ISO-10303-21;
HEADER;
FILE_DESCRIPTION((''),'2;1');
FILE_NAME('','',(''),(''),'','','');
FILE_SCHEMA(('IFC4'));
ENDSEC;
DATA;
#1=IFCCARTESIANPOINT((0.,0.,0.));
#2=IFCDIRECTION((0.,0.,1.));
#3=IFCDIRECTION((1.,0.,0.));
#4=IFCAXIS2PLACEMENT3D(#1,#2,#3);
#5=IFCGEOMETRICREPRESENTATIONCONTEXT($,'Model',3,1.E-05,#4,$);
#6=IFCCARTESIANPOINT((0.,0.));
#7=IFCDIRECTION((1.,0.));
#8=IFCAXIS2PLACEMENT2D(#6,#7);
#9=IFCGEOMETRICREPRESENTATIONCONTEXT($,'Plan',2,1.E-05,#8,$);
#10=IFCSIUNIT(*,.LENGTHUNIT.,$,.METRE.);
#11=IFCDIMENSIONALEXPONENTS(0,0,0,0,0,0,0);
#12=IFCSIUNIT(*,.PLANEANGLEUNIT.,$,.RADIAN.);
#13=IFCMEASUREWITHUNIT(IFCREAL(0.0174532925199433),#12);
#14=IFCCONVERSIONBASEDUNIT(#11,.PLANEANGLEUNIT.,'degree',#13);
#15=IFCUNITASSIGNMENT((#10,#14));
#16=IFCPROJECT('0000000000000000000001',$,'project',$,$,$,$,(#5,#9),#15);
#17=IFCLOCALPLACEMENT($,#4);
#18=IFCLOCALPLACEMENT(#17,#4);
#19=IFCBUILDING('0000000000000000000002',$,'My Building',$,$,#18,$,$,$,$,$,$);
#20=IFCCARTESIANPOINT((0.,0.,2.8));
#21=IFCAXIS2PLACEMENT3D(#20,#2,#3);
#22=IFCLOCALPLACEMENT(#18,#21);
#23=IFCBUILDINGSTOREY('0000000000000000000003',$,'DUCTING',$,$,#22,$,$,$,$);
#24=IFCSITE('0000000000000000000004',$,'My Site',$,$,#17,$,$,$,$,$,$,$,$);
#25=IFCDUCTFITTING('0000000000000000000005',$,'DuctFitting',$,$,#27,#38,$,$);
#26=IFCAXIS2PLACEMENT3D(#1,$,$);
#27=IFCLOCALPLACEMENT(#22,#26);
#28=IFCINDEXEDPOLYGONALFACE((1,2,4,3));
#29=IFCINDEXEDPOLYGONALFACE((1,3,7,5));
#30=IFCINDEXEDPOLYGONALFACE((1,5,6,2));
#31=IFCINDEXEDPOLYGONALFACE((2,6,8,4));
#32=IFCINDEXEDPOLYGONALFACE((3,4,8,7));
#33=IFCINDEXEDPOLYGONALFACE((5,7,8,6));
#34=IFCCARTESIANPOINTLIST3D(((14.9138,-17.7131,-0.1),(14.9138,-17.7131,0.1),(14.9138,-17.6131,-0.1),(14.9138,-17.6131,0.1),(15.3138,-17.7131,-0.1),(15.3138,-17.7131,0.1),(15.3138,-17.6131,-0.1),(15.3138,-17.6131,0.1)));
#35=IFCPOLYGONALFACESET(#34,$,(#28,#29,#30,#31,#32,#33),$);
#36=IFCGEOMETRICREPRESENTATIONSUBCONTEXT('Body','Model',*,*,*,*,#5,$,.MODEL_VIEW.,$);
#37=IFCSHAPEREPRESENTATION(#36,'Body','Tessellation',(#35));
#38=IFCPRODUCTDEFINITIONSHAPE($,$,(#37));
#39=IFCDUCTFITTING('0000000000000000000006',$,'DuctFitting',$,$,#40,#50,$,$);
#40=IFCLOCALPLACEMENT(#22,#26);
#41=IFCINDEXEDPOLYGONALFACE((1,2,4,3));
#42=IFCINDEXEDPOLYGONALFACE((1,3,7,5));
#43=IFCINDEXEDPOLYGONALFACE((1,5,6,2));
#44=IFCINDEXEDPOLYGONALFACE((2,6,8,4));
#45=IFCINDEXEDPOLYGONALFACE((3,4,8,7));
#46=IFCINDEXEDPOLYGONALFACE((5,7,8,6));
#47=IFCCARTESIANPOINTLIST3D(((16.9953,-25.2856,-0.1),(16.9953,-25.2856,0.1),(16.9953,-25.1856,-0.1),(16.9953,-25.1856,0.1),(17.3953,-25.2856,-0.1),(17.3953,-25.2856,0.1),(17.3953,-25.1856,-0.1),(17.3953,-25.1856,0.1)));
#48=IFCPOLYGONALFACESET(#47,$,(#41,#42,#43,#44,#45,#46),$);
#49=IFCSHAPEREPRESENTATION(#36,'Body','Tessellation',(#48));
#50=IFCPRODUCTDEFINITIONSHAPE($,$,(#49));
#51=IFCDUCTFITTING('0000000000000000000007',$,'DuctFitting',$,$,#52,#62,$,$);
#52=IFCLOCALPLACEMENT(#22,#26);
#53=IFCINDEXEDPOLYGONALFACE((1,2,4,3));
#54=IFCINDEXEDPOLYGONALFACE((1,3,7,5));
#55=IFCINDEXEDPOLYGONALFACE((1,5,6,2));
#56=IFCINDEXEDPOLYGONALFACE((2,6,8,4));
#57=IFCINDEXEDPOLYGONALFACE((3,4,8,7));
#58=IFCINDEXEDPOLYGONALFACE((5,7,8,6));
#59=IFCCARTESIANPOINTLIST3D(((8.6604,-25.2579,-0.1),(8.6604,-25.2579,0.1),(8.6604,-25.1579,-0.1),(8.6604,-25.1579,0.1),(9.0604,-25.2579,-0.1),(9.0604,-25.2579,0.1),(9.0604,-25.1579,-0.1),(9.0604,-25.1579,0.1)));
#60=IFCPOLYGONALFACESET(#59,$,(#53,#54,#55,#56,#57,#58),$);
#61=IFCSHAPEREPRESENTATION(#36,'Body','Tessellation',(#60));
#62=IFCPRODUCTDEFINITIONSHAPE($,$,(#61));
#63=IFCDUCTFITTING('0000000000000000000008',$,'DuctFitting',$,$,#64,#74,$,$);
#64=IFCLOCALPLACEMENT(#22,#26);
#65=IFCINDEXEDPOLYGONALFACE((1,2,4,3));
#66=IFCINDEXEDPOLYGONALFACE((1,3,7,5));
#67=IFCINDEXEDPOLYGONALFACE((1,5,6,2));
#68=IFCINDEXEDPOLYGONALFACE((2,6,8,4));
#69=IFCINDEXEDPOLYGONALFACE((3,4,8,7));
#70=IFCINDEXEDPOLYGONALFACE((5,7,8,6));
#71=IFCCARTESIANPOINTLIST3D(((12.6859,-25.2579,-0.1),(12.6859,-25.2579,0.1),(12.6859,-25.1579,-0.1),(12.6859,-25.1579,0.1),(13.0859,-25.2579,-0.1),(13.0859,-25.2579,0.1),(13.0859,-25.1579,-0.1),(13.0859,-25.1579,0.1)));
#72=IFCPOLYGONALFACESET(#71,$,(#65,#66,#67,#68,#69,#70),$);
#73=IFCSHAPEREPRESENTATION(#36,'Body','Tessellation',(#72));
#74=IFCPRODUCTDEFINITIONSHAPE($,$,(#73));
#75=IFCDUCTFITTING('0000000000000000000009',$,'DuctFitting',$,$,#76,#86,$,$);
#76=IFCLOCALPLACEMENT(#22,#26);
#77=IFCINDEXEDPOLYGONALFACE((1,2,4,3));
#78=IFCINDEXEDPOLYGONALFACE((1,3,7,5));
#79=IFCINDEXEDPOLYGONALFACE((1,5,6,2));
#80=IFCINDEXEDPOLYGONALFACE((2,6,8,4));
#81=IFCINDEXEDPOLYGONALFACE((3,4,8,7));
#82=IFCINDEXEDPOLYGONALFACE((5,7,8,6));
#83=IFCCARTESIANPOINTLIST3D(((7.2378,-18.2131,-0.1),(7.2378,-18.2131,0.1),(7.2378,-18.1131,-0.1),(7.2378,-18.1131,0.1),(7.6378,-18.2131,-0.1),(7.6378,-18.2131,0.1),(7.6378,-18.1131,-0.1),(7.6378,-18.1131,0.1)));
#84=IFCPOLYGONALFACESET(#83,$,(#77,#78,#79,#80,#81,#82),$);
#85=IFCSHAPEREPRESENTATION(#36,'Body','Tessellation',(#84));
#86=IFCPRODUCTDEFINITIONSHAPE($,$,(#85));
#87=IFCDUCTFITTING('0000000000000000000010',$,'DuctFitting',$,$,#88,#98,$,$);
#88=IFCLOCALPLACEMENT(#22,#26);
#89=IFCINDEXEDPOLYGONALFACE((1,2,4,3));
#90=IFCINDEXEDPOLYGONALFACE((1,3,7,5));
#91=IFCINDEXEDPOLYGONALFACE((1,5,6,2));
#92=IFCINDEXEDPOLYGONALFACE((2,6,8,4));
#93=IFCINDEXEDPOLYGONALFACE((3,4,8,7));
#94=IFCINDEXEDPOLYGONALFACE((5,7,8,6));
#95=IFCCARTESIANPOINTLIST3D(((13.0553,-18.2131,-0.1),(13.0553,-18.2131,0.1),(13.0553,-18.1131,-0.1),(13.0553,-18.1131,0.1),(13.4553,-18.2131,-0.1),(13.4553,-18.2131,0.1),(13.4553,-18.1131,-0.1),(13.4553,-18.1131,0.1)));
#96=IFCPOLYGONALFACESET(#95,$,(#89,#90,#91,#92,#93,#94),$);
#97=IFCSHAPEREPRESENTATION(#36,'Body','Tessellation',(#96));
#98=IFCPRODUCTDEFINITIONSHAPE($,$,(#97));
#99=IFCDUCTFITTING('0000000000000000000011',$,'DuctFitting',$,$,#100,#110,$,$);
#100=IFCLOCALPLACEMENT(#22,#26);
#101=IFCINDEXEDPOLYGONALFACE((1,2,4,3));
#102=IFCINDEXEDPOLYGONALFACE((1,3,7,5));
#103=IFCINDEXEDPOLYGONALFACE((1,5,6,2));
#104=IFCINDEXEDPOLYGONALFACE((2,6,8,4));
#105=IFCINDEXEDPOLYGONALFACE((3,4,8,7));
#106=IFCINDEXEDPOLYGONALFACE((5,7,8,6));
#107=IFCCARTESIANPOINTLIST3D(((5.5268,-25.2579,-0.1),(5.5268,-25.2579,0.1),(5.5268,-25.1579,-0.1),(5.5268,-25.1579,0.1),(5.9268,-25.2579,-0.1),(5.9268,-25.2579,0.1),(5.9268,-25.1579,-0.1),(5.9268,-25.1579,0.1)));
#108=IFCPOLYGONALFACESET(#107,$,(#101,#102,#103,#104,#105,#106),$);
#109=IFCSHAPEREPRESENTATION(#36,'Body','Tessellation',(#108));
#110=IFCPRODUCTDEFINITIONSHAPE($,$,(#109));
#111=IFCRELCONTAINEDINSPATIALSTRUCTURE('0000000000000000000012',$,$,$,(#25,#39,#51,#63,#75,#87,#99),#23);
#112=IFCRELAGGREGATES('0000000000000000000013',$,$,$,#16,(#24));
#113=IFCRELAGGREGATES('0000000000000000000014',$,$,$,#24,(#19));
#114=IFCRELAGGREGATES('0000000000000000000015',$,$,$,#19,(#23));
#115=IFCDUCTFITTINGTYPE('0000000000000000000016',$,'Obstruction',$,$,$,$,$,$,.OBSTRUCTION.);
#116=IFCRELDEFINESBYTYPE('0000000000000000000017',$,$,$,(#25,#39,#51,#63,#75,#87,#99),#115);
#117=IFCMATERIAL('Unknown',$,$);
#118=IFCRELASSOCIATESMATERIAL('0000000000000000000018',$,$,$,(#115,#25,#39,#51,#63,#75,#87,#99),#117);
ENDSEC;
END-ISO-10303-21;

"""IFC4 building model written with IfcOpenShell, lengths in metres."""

from ifc_helpers import new_model, entity, si_unit, converted_unit, frame, origin_with_axes, origin_2d_with_axis, place, context, subcontext, project, spatial, rectangle, extrude, material, material_profile, profile_set, profile_usage, type_object, element, save


model = new_model("IFC4")

# Units and contexts
model_context = context("Model", 3, precision=1e-05, world=origin_with_axes())
plan_context = context("Plan", 2, precision=1e-05, world=origin_2d_with_axis())
body_context = subcontext(model_context, "Body", "Model", "MODEL_VIEW")
ifc_project = project(units=[si_unit("LENGTHUNIT", "METRE"), converted_unit("PLANEANGLEUNIT", "degree", entity("IfcReal", 0.0174532925199433), si_unit("PLANEANGLEUNIT", "RADIAN"), dimensions=[0, 0, 0, 0, 0, 0, 0])], contexts=[model_context, plan_context])

# Site, building, storey
site_placement = place(None, origin_with_axes())
site = spatial("IfcSite", under=ifc_project, at=site_placement, Name="My Site")
building_placement = place(site_placement, origin_with_axes())
building = spatial("IfcBuilding", under=site, at=building_placement, Name="My Building")
storey_placement = place(building_placement, frame((0.0, 0.0, 2.8), z_axis=(0.0, 0.0, 1.0), x_axis=(1.0, 0.0, 0.0)))
storey = spatial("IfcBuildingStorey", under=building, at=storey_placement, Name="DUCTING")

# Shared definitions
ifc_material = material(Name="Unknown")

# Duct fittings
ifc_material_profile_1 = material_profile(ifc_material, rectangle(XDim=0.4, YDim=0.2))
ifc_profile_set_1 = profile_set([ifc_material_profile_1])
duct_fitting_type = type_object("IfcDuctFittingType", Name="Obstruction", PredefinedType="OBSTRUCTION", material=ifc_profile_set_1)
ifc_profile_usage_1 = profile_usage(ifc_profile_set_1, cardinal=5)
duct_fitting_1_placement = place(storey_placement, frame((15.1138, -17.6131, 0.0), z_axis=(0.0, -1.0, 0.0), x_axis=(1.0, 0.0, 0.0)))
element("IfcDuctFitting", 1, at=duct_fitting_1_placement, inside=storey, type_object=duct_fitting_type, material=ifc_profile_usage_1, Name="DuctFitting", context=body_context, shape_type="SweptSolid", body=[
    extrude(rectangle(XDim=0.4, YDim=0.2), origin_with_axes(), (0.0, 0.0, 1.0), 0.1),
])
ifc_profile_usage_2 = profile_usage(ifc_profile_set_1, cardinal=5)
duct_fitting_2_placement = place(storey_placement, frame((17.1953, -25.2856, 0.0), z_axis=(0.0, 1.0, 0.0), x_axis=(-1.0, 0.0, 0.0)))
element("IfcDuctFitting", 2, at=duct_fitting_2_placement, inside=storey, type_object=duct_fitting_type, material=ifc_profile_usage_2, Name="DuctFitting", context=body_context, shape_type="SweptSolid", body=[
    extrude(rectangle(XDim=0.4, YDim=0.2), origin_with_axes(), (0.0, 0.0, 1.0), 0.1),
])
ifc_profile_usage_3 = profile_usage(ifc_profile_set_1, cardinal=5)
duct_fitting_3_placement = place(storey_placement, frame((8.8604, -25.2579, 0.0), z_axis=(0.0, 1.0, 0.0), x_axis=(-1.0, 0.0, 0.0)))
element("IfcDuctFitting", 3, at=duct_fitting_3_placement, inside=storey, type_object=duct_fitting_type, material=ifc_profile_usage_3, Name="DuctFitting", context=body_context, shape_type="SweptSolid", body=[
    extrude(rectangle(XDim=0.4, YDim=0.2), origin_with_axes(), (0.0, 0.0, 1.0), 0.1),
])
ifc_profile_usage_4 = profile_usage(ifc_profile_set_1, cardinal=5)
duct_fitting_4_placement = place(storey_placement, frame((12.8859, -25.2579, 0.0), z_axis=(0.0, 1.0, 0.0), x_axis=(-1.0, 0.0, 0.0)))
element("IfcDuctFitting", 4, at=duct_fitting_4_placement, inside=storey, type_object=duct_fitting_type, material=ifc_profile_usage_4, Name="DuctFitting", context=body_context, shape_type="SweptSolid", body=[
    extrude(rectangle(XDim=0.4, YDim=0.2), origin_with_axes(), (0.0, 0.0, 1.0), 0.1),
])
ifc_profile_usage_5 = profile_usage(ifc_profile_set_1, cardinal=5)
duct_fitting_5_placement = place(storey_placement, frame((7.4378, -18.2131, 0.0), z_axis=(0.0, 1.0, 0.0), x_axis=(-1.0, 0.0, 0.0)))
element("IfcDuctFitting", 5, at=duct_fitting_5_placement, inside=storey, type_object=duct_fitting_type, material=ifc_profile_usage_5, Name="DuctFitting", context=body_context, shape_type="SweptSolid", body=[
    extrude(rectangle(XDim=0.4, YDim=0.2), origin_with_axes(), (0.0, 0.0, 1.0), 0.1),
])
ifc_profile_usage_6 = profile_usage(ifc_profile_set_1, cardinal=5)
duct_fitting_6_placement = place(storey_placement, frame((13.2553, -18.2131, 0.0), z_axis=(0.0, 1.0, 0.0), x_axis=(-1.0, 0.0, 0.0)))
element("IfcDuctFitting", 6, at=duct_fitting_6_placement, inside=storey, type_object=duct_fitting_type, material=ifc_profile_usage_6, Name="DuctFitting", context=body_context, shape_type="SweptSolid", body=[
    extrude(rectangle(XDim=0.4, YDim=0.2), origin_with_axes(), (0.0, 0.0, 1.0), 0.1),
])
ifc_profile_usage_7 = profile_usage(ifc_profile_set_1, cardinal=5)
duct_fitting_7_placement = place(storey_placement, frame((5.7268, -25.2579, 0.0), z_axis=(0.0, 1.0, 0.0), x_axis=(-1.0, 0.0, 0.0)))
element("IfcDuctFitting", 7, at=duct_fitting_7_placement, inside=storey, type_object=duct_fitting_type, material=ifc_profile_usage_7, Name="DuctFitting", context=body_context, shape_type="SweptSolid", body=[
    extrude(rectangle(XDim=0.4, YDim=0.2), origin_with_axes(), (0.0, 0.0, 1.0), 0.1),
])

save(model, "model.ifc")
